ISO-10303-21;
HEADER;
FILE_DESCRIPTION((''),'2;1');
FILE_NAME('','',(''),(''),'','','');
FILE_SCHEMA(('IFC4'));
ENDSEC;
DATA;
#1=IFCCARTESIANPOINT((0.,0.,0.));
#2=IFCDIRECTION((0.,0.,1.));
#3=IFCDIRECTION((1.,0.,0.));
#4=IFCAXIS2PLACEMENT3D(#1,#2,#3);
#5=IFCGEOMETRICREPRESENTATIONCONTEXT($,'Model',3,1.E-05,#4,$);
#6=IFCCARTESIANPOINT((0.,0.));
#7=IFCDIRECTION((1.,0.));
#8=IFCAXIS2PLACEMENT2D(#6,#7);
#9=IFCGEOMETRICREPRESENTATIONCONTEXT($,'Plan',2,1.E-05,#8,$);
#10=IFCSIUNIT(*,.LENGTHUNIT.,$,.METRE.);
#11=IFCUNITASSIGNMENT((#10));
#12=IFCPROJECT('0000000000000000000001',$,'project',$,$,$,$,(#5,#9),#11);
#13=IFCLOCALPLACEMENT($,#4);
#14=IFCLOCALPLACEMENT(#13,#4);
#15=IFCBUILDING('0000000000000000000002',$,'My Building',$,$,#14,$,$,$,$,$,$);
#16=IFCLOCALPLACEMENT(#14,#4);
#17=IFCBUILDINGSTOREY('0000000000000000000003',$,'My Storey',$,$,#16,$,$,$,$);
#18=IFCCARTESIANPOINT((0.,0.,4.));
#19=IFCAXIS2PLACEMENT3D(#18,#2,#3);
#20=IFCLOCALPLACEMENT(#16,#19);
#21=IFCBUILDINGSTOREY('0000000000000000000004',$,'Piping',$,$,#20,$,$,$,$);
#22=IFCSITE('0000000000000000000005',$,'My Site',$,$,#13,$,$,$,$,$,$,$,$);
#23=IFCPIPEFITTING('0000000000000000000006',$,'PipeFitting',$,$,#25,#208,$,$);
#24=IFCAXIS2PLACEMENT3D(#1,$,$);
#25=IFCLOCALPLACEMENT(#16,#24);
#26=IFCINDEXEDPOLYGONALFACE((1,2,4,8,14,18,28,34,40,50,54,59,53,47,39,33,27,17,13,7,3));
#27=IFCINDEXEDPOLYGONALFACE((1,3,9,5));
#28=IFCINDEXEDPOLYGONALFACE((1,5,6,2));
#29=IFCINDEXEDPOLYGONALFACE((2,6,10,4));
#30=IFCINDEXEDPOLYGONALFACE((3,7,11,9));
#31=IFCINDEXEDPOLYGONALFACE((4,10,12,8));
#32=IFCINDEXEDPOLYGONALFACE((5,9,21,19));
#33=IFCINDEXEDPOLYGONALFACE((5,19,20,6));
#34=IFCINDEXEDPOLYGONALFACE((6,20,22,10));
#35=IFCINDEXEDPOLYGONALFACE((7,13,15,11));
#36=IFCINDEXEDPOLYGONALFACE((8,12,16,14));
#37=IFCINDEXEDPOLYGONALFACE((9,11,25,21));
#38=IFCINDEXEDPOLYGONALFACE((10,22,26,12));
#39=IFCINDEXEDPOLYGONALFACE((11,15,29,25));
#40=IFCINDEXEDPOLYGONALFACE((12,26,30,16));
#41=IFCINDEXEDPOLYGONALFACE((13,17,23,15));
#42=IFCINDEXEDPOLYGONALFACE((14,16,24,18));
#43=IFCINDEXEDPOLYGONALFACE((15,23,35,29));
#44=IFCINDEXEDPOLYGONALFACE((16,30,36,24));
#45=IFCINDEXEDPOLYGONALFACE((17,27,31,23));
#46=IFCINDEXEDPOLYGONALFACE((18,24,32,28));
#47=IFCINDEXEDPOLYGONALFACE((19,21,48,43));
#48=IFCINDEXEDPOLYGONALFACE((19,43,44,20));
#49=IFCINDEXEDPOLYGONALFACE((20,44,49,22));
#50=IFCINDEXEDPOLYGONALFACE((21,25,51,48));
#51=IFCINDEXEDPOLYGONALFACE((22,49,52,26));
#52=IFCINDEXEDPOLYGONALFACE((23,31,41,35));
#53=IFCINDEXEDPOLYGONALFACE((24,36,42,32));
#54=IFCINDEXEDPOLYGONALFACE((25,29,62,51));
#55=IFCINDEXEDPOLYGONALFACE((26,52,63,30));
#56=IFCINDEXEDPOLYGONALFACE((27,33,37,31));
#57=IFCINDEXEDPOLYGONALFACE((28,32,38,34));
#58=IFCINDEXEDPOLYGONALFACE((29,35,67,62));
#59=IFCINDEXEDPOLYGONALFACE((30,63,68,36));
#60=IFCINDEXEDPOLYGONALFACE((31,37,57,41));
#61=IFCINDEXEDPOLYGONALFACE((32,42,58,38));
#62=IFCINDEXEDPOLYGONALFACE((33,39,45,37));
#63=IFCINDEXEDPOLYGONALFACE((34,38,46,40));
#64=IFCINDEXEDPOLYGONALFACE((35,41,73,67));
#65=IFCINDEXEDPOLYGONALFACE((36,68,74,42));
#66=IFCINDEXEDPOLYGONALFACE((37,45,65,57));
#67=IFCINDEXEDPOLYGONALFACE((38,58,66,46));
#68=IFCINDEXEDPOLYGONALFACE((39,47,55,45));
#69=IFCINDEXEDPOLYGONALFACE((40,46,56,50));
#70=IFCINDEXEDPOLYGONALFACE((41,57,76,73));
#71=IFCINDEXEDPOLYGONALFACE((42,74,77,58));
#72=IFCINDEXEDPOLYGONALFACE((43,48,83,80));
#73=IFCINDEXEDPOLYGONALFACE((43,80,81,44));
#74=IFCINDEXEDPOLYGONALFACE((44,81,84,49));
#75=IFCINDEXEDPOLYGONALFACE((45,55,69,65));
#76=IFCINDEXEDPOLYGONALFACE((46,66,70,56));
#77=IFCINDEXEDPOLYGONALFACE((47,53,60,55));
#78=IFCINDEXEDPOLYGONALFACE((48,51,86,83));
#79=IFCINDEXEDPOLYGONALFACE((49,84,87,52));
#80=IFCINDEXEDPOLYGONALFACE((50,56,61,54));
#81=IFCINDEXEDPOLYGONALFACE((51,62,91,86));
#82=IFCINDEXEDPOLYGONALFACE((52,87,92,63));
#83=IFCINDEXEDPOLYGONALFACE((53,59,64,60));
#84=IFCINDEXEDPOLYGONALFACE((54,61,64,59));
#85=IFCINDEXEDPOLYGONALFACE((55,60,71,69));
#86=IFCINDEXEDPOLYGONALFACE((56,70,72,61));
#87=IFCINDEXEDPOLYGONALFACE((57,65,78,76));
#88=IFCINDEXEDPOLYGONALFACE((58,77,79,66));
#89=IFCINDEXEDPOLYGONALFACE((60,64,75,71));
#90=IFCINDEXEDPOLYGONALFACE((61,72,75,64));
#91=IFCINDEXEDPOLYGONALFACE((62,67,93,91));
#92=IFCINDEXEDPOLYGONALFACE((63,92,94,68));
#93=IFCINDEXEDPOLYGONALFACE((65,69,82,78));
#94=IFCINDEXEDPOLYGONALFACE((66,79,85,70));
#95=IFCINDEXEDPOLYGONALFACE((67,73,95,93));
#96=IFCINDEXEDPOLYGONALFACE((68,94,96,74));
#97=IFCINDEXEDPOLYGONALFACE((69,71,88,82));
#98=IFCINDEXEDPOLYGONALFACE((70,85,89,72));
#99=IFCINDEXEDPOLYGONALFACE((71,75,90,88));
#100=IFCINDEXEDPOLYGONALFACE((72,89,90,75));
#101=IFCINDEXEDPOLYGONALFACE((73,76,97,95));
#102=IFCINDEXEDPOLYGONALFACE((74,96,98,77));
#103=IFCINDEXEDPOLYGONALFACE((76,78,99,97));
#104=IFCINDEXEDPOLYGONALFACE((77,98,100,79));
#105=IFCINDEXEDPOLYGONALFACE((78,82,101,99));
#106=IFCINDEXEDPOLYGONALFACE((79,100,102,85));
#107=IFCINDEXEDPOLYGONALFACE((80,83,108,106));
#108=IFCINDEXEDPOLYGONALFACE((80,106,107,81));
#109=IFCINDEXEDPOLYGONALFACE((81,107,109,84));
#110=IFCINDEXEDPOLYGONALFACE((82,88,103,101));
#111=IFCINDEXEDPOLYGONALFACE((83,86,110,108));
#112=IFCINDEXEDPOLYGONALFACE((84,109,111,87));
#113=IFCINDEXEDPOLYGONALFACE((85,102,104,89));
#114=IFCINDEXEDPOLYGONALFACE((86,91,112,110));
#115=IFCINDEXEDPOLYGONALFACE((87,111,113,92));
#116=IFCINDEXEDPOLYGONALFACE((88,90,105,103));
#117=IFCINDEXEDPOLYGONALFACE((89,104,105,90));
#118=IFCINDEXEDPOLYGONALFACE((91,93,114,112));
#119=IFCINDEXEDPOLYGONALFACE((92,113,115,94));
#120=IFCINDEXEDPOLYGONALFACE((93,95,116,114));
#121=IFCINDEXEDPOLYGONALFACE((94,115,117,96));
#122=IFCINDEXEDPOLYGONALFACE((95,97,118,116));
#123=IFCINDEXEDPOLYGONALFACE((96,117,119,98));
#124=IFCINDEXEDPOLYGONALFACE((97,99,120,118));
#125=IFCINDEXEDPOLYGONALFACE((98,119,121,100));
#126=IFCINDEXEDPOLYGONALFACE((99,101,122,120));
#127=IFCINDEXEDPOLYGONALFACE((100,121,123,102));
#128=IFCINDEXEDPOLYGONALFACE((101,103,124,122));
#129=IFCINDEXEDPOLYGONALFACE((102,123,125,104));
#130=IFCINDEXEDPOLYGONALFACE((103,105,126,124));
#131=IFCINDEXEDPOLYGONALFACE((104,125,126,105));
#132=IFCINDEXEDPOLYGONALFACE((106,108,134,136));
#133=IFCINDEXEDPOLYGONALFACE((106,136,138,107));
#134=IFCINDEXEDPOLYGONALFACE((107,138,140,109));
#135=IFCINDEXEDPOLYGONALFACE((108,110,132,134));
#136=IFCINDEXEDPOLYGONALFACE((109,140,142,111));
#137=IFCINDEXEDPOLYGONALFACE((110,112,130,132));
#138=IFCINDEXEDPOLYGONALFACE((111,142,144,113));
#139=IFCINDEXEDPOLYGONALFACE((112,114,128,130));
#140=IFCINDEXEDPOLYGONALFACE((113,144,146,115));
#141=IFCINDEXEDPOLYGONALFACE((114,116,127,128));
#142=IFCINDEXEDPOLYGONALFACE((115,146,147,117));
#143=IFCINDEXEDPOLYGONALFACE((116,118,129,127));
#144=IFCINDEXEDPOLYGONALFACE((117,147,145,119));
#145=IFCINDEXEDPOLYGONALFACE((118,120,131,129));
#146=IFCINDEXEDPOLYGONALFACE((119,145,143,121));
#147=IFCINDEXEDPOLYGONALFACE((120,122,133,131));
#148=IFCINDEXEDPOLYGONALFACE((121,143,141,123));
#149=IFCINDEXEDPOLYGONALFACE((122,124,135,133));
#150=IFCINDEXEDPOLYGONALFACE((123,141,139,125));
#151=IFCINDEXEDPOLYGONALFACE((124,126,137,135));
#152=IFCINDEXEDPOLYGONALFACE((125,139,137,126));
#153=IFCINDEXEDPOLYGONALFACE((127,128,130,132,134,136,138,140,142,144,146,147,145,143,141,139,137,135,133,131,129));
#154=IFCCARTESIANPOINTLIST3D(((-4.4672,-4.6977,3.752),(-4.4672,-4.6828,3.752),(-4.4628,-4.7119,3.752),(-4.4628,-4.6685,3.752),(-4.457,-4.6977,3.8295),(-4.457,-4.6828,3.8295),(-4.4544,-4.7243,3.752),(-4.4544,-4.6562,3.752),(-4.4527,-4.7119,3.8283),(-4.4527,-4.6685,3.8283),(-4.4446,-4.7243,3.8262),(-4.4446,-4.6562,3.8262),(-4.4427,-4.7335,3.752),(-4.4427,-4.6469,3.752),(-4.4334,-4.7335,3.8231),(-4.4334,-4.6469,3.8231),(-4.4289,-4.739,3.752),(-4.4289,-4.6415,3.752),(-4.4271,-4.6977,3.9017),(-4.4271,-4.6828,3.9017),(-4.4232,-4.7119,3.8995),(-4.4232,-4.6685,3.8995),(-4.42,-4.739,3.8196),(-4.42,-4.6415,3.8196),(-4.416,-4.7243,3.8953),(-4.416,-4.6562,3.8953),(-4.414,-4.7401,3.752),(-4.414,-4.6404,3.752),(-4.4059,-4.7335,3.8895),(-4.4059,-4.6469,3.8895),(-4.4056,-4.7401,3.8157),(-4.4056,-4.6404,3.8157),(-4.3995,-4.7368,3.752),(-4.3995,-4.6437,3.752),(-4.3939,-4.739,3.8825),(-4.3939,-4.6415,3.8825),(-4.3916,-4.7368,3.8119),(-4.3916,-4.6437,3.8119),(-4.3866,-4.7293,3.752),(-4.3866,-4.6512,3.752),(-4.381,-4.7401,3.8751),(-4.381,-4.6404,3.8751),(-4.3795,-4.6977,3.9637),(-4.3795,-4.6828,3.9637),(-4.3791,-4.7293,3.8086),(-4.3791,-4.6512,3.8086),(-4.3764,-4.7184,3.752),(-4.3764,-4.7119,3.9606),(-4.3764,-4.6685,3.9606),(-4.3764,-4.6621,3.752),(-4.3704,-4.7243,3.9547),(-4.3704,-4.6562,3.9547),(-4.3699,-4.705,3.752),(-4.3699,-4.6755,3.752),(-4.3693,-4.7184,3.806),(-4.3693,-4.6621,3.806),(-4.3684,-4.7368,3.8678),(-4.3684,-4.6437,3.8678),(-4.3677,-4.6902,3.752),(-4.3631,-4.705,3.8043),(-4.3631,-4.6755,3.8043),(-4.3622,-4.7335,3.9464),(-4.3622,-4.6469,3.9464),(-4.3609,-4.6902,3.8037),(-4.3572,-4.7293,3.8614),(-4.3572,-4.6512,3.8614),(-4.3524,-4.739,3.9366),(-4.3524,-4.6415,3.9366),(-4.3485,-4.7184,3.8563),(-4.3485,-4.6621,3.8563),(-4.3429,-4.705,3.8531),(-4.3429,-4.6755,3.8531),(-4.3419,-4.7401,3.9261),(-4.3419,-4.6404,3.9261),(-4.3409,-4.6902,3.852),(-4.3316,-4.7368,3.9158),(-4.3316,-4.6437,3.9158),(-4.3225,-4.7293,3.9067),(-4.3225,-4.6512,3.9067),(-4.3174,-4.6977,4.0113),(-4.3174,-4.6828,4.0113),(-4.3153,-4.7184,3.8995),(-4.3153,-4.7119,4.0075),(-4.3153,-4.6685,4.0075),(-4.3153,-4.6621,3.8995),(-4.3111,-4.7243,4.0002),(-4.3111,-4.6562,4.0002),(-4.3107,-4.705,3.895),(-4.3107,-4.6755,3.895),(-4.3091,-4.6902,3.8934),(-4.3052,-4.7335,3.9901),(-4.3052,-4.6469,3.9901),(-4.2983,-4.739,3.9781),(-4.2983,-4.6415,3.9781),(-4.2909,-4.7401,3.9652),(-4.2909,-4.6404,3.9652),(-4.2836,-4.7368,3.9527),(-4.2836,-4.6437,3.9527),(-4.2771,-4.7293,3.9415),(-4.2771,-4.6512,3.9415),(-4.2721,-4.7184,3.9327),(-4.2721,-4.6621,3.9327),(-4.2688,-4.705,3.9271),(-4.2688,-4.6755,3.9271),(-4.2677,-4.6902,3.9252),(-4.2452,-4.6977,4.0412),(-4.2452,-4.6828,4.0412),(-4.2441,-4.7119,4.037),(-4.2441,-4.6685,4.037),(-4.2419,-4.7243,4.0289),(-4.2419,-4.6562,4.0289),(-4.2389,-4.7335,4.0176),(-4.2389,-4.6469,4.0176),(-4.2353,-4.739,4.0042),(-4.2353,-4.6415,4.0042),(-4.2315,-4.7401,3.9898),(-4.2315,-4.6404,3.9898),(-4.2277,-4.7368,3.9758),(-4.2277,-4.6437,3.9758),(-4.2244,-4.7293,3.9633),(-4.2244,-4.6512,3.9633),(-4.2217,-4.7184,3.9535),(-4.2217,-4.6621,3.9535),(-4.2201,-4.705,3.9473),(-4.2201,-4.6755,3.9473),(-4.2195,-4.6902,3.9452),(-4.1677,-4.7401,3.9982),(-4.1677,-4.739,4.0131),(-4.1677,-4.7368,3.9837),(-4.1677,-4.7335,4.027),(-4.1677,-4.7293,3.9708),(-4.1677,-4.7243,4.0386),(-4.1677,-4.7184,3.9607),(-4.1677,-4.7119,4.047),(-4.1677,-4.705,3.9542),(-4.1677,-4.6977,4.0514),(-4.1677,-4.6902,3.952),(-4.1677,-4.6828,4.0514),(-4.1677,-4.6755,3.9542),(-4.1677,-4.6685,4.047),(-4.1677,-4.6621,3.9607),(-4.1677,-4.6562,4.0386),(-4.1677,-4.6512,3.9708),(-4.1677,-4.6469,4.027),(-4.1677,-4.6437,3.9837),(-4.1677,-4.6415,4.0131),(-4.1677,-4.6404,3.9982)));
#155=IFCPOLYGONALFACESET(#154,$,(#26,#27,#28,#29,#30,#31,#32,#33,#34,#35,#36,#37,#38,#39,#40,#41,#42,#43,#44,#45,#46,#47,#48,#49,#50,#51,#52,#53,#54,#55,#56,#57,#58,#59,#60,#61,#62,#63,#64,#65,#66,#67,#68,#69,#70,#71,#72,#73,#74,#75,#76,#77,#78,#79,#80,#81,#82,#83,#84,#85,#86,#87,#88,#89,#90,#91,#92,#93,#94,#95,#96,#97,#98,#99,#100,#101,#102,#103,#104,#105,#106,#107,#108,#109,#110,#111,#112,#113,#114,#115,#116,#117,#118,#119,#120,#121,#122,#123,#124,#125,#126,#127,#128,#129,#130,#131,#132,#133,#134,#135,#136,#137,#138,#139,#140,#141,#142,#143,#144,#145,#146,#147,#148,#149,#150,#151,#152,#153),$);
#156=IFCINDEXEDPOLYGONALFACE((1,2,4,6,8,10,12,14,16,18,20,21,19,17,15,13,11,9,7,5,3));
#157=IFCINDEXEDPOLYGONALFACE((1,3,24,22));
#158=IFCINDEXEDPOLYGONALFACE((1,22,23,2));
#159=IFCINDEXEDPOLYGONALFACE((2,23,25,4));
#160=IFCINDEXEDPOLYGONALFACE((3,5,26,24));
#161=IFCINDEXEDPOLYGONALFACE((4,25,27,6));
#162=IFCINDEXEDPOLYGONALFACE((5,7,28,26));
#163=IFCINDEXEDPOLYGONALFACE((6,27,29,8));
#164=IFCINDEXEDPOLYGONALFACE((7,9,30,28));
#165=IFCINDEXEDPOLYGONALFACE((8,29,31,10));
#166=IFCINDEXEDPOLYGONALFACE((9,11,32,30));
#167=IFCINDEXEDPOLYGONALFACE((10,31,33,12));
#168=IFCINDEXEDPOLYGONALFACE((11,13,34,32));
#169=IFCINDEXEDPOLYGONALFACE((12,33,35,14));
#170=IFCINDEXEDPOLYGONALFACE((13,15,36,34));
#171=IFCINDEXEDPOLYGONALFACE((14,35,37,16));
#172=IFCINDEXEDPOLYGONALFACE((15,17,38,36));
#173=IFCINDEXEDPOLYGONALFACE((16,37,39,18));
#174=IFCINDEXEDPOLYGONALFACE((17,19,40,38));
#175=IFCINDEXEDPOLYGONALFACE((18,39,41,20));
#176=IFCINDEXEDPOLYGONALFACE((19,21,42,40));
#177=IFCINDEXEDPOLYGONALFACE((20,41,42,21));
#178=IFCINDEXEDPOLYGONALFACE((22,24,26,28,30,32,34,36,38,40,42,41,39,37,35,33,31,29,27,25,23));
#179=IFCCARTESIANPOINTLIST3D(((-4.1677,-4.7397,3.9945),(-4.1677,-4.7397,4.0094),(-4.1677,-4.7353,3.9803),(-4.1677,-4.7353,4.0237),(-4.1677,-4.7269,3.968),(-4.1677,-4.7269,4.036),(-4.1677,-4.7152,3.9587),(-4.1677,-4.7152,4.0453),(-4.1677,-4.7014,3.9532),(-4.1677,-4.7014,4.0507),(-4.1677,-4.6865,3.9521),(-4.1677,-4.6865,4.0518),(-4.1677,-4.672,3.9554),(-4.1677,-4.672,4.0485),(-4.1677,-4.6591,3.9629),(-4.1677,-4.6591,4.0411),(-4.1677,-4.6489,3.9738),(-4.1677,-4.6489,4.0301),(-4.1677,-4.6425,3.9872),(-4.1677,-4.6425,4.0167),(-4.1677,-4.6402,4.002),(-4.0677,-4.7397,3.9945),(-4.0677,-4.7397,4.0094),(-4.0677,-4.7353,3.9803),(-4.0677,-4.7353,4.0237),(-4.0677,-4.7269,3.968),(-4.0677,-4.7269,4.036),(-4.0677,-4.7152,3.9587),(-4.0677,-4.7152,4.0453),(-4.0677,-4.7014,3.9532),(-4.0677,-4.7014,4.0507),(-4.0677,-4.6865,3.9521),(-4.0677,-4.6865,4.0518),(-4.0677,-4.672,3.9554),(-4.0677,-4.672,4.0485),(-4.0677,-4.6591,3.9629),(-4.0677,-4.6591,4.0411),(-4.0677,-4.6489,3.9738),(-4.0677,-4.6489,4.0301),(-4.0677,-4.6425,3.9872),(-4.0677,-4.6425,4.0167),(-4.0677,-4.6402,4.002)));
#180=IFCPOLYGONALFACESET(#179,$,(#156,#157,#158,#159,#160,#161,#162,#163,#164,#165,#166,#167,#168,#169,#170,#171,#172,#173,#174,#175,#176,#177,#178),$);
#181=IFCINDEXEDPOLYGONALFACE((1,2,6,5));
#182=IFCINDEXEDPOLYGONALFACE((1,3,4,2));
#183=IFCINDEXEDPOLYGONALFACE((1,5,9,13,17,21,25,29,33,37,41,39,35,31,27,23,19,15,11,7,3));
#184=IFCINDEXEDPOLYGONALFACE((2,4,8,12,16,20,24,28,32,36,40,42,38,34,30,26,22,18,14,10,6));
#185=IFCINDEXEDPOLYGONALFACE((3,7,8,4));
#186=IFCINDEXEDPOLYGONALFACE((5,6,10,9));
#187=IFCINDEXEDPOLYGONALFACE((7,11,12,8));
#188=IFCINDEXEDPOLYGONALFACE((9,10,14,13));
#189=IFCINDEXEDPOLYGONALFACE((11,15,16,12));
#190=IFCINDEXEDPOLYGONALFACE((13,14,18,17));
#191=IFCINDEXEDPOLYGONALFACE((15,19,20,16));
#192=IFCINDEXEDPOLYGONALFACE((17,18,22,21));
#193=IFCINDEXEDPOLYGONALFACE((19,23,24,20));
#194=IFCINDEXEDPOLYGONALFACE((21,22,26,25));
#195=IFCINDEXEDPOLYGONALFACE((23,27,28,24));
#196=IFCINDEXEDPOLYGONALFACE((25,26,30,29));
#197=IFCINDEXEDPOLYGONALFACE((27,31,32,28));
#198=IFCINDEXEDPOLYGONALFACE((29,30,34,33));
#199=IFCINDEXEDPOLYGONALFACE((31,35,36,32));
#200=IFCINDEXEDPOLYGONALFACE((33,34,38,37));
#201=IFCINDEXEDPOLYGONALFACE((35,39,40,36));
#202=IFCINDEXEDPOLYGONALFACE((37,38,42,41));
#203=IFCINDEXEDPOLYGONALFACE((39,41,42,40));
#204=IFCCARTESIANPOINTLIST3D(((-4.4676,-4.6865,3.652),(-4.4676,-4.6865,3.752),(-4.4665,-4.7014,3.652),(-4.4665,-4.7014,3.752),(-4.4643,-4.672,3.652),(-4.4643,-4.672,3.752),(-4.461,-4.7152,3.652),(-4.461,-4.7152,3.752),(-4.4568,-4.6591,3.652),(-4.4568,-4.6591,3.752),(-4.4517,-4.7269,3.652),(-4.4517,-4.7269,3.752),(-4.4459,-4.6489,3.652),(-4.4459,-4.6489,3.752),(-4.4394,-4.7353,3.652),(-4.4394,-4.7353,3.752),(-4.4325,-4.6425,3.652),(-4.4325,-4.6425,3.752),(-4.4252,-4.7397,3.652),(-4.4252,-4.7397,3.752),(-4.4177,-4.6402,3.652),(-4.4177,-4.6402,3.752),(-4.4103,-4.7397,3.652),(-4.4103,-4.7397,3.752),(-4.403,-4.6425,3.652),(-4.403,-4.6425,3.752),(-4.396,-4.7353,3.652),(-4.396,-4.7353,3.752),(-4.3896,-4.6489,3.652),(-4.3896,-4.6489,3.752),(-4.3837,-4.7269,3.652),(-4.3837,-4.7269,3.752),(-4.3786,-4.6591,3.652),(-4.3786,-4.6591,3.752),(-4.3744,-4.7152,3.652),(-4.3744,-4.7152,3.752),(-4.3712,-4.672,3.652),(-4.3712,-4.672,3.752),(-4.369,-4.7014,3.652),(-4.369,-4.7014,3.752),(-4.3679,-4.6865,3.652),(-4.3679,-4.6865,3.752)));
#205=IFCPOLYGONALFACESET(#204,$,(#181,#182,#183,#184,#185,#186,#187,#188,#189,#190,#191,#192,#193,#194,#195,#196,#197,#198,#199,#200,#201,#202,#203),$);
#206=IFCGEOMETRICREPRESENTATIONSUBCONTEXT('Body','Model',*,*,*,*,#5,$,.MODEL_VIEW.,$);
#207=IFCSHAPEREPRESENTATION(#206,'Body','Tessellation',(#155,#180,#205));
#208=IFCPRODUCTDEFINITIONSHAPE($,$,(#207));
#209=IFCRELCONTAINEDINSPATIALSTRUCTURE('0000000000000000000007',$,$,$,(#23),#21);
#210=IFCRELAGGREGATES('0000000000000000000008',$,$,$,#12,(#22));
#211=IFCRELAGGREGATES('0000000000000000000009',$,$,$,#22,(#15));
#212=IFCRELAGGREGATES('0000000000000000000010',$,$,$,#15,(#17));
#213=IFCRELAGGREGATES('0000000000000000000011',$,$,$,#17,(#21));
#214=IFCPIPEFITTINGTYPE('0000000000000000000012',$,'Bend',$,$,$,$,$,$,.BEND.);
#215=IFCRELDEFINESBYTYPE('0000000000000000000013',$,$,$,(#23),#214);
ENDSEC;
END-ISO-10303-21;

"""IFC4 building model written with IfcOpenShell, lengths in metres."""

from ifc_helpers import new_model, entity, si_unit, frame, origin_with_axes, origin_2d_with_axis, place, context, subcontext, project, spatial, line, indexed_curve, circle, outline, extrude, source, transform, mapped, type_object, type_shapes, element, save


model = new_model("IFC4")

# Units and contexts
model_context = context("Model", 3, precision=1e-05, world=origin_with_axes())
plan_context = context("Plan", 2, precision=1e-05, world=origin_2d_with_axis())
body_context = subcontext(model_context, "Body", "Model", "MODEL_VIEW")
ifc_project = project(units=[si_unit("LENGTHUNIT", "METRE")], contexts=[model_context, plan_context])

# Site, building, storeys
site_placement = place(None, origin_with_axes())
site = spatial("IfcSite", under=ifc_project, at=site_placement, Name="My Site")
building_placement = place(site_placement, origin_with_axes())
building = spatial("IfcBuilding", under=site, at=building_placement, Name="My Building")
storey_1_placement = place(building_placement, origin_with_axes())
storey_1 = spatial("IfcBuildingStorey", under=building, at=storey_1_placement, Name="My Storey")
storey_2_placement = place(storey_1_placement, frame((0.0, 0.0, 4.0), z_axis=(0.0, 0.0, 1.0), x_axis=(1.0, 0.0, 0.0)))
storey_2 = spatial("IfcBuildingStorey", under=storey_1, at=storey_2_placement, Name="Piping")

# Shared definitions
pipe_fitting_type_1 = type_object("IfcPipeFittingType", Name="Bend", PredefinedType="BEND")
shared_shape = source(origin_with_axes(), body_context, "Body", "SolidModel", [
    entity("IfcSweptDiskSolid", entity("IfcIndexedPolyCurve", entity("IfcCartesianPointList3D", [[0.0, 0.0, -0.1], [0.0, -0.0732, -0.2768], [0.0, -0.25, -0.35]]), [entity("IfcArcIndex", [1, 2, 3])]), 0.05),
    extrude(circle(Radius=0.05), origin_with_axes(), (0.0, 0.0, -1.0), 0.1),
    extrude(circle(Radius=0.05), frame((0.0, -0.25, -0.35), z_axis=(0.0, -1.0, 0.0), x_axis=(1.0, 0.0, 0.0)), (0.0, 0.0, 1.0), 0.1),
])
type_shapes(pipe_fitting_type_1, [shared_shape])

# Pipe fitting, opening
pipe_fitting_1_placement = place(storey_2_placement, frame((-4.0677, -4.6902, 0.002), z_axis=(1.0, 0.0, 0.0), x_axis=(0.0, 1.0, 0.0)))
pipe_fitting_1 = element("IfcPipeFitting", 1, at=pipe_fitting_1_placement, inside=storey_2, type_object=pipe_fitting_type_1, Name="PipeFitting", context=body_context, shape_type="MappedRepresentation", body=[
    mapped(shared_shape, transform((0.0, 0.0, 0.0), x_axis=(1.0, 0.0, 0.0), y_axis=(0.0, 1.0, 0.0), z_axis=(0.0, 0.0, 1.0), scale=1.0)),
])
opening_1_placement = place(pipe_fitting_1_placement, frame((4.6902, -4.002, 4.0677), z_axis=(0.0, 1.0, 0.0), x_axis=(0.0, 0.0, 1.0)))
element("IfcOpeningElement", 2, at=opening_1_placement, cuts=pipe_fitting_1, PredefinedType="OPENING", context=body_context, shape_type="SweptSolid", body=[
    extrude(outline(indexed_curve([(0.0, 0.0), (0.5, 0.0), (0.5, 0.5), (0.0, 0.5)], segments=[line(1, 2, 3, 4, 1)])), origin_with_axes(), (0.0, 0.0, 1.0), 0.5),
])

save(model, "model.ifc")
